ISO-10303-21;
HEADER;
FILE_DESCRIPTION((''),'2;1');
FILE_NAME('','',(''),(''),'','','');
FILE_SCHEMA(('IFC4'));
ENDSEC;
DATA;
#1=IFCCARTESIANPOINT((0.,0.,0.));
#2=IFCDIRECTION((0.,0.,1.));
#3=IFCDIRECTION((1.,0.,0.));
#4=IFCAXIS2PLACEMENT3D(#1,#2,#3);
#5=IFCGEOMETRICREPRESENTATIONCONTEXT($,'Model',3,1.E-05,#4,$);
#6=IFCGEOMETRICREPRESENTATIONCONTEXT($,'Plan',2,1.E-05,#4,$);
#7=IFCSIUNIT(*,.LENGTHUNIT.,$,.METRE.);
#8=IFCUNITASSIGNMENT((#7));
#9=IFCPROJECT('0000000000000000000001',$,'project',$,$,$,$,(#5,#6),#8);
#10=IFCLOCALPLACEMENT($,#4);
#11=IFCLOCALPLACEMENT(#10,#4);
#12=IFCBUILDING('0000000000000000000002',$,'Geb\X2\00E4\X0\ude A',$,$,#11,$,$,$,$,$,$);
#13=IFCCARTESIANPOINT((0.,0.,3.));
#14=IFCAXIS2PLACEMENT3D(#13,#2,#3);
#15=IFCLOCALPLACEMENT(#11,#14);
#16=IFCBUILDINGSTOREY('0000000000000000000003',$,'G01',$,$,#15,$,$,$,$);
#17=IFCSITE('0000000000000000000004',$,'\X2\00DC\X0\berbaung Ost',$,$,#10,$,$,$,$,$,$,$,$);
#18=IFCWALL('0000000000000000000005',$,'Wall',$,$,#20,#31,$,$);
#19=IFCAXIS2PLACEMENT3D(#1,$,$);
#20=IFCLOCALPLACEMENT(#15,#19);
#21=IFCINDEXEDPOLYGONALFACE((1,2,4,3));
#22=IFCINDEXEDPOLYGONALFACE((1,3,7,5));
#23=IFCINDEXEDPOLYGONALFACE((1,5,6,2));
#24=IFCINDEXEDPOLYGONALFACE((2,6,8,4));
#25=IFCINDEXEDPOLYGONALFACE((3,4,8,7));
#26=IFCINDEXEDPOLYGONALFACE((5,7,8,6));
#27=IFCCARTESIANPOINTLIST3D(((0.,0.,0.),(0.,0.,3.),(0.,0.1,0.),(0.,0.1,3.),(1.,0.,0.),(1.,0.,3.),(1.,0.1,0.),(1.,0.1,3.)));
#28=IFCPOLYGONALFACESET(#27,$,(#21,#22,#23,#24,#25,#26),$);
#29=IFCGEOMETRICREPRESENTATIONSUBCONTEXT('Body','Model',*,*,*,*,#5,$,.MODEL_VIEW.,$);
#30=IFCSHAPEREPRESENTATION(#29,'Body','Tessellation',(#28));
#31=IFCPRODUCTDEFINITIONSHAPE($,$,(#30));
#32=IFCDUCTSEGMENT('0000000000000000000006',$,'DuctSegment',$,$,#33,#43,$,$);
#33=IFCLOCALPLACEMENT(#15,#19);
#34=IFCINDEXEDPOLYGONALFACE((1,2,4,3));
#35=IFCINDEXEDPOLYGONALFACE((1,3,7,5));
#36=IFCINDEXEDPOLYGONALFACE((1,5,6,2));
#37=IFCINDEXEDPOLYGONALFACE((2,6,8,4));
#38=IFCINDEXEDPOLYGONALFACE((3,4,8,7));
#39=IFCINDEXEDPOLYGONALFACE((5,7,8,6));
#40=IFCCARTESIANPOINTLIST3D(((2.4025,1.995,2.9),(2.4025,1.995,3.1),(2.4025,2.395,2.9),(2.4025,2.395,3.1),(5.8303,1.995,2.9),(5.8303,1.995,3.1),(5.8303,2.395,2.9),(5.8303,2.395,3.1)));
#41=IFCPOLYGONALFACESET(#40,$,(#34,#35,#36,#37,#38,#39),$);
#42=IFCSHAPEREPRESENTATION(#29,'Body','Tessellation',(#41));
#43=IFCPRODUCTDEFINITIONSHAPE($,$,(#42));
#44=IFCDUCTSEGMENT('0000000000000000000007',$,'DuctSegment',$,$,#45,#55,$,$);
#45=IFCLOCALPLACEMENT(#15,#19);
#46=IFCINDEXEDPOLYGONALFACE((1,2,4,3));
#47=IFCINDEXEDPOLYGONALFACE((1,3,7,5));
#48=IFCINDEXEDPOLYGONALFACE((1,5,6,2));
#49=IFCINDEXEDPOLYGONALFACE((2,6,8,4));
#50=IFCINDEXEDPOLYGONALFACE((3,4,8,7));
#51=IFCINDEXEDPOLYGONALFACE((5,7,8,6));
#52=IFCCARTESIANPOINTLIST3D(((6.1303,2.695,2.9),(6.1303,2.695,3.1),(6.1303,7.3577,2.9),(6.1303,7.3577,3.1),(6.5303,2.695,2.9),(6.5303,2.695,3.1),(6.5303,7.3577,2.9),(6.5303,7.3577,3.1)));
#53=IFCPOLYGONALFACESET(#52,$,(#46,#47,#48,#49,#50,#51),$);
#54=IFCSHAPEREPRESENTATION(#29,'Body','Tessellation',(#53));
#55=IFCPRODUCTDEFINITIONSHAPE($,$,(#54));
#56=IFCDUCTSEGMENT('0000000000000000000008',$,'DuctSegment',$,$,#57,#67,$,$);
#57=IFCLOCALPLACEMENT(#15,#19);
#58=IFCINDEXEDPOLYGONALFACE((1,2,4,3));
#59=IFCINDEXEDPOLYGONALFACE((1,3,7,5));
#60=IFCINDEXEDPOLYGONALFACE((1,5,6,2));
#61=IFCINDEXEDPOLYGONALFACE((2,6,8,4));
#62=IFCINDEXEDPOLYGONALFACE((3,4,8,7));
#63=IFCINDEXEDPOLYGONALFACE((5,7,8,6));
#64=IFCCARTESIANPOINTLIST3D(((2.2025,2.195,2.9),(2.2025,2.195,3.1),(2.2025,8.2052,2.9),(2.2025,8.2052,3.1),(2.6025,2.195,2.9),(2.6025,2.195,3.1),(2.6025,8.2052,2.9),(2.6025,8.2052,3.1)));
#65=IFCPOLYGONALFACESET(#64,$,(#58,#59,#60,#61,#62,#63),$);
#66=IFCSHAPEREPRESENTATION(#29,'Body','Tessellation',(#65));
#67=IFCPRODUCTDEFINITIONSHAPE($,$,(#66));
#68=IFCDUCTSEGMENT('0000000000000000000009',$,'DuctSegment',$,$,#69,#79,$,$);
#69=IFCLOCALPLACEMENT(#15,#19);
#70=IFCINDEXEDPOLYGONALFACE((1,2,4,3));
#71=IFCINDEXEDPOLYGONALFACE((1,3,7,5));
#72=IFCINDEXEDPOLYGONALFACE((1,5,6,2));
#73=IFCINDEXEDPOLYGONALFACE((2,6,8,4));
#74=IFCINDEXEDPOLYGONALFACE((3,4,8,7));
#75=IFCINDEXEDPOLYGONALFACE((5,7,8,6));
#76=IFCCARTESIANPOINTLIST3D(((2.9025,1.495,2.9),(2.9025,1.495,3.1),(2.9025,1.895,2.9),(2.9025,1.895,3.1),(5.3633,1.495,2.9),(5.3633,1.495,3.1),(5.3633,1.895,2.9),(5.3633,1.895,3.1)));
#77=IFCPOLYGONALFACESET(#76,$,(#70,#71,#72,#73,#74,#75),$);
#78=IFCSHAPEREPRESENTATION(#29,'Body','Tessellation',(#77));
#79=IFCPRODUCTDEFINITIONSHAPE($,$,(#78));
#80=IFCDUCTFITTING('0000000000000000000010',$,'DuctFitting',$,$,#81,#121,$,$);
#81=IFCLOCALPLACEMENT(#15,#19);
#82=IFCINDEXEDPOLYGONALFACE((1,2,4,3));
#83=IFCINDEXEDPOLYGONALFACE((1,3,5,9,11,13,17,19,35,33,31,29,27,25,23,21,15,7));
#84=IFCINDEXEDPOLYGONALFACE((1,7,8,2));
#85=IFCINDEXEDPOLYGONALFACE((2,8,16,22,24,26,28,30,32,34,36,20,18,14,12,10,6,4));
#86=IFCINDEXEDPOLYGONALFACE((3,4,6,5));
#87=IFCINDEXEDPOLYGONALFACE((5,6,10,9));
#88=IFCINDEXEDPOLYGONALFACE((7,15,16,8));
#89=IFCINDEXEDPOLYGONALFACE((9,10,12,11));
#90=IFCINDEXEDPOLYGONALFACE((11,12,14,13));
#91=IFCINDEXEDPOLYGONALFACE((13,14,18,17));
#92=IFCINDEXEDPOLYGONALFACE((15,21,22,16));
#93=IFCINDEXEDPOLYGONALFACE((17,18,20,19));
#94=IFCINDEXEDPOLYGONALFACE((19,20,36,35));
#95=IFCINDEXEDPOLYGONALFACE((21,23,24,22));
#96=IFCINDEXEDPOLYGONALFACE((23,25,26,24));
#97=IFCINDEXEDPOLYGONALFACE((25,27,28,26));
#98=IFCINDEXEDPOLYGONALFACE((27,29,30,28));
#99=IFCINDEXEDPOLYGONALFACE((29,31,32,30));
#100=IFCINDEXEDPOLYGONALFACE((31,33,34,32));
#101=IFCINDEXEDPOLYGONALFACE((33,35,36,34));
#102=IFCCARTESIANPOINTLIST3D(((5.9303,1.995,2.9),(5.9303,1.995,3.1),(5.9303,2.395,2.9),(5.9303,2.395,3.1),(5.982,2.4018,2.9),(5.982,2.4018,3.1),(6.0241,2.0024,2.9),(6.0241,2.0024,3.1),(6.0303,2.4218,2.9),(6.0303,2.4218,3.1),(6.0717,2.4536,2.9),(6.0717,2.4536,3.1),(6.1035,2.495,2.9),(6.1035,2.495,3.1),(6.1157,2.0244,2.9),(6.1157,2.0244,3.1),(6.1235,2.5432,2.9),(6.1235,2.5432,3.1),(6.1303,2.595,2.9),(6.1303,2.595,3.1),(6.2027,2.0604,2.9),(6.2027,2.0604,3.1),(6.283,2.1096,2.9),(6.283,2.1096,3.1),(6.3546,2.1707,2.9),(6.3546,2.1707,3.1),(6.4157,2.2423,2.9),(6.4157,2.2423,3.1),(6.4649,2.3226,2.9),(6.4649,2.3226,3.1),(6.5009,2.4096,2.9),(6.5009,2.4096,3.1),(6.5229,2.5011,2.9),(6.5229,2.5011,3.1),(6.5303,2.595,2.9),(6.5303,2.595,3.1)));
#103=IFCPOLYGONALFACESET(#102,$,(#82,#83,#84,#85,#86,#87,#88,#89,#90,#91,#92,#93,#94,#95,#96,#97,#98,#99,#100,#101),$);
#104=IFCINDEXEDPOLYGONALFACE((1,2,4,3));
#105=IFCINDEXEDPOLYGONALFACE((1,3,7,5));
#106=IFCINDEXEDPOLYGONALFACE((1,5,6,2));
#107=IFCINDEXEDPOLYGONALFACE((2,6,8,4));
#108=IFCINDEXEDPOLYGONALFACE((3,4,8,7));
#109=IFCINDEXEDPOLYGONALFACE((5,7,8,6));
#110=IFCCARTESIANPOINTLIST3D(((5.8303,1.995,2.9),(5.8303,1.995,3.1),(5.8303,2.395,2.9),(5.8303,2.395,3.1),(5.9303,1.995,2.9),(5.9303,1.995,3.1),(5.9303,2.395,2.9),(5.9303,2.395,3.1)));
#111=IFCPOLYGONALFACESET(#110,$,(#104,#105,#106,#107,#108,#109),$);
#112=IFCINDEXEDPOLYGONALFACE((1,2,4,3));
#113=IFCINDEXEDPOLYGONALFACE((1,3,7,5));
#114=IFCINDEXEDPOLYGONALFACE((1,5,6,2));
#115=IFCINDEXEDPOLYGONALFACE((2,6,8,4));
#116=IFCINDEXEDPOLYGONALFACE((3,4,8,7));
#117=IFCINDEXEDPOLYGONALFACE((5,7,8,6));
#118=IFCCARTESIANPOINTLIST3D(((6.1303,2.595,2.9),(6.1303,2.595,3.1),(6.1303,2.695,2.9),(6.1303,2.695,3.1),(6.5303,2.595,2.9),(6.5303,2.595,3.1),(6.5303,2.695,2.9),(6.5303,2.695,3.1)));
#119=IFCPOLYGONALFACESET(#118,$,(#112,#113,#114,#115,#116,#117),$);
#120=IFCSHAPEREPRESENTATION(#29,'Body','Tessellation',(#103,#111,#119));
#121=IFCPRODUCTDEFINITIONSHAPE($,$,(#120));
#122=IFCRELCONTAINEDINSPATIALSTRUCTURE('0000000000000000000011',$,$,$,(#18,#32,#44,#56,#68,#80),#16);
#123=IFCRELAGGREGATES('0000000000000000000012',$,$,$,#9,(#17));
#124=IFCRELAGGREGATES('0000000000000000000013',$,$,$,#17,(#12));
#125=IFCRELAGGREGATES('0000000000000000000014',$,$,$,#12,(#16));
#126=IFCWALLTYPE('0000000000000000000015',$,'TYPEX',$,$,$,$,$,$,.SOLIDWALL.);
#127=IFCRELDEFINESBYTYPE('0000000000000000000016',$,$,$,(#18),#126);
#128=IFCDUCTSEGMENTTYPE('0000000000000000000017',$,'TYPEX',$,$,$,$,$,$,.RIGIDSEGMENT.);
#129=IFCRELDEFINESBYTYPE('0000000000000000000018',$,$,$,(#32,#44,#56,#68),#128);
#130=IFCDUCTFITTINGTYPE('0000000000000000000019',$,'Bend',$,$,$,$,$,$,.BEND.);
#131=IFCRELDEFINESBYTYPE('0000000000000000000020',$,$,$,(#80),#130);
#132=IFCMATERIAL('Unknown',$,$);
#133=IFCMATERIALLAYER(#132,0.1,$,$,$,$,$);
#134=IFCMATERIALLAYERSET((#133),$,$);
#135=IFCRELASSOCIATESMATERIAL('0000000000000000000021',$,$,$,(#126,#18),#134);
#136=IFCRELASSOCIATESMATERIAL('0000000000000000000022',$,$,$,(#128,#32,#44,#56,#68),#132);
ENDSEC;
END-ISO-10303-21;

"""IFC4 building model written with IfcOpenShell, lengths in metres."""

from ifc_helpers import new_model, si_unit, frame, origin_with_axes, place, context, subcontext, project, spatial, line, arc, indexed_curve, rectangle, outline, extrude, source, transform, mapped, material, layer, layer_set, layer_usage, material_profile, profile_set, profile_usage, type_object, type_shapes, element, save


model = new_model("IFC4")

# Units and contexts
model_context = context("Model", 3, precision=1e-05, world=origin_with_axes())
plan_context = context("Plan", 2, precision=1e-05, world=origin_with_axes())
body_context = subcontext(model_context, "Body", "Model", "MODEL_VIEW")
ifc_project = project(units=[si_unit("LENGTHUNIT", "METRE")], contexts=[model_context, plan_context])

# Site, building, storey
site_placement = place(None, origin_with_axes())
site = spatial("IfcSite", under=ifc_project, at=site_placement, Name="Überbaung Ost")
building_placement = place(site_placement, origin_with_axes())
building = spatial("IfcBuilding", under=site, at=building_placement, Name="Gebäude A")
storey_placement = place(building_placement, frame((0.0, 0.0, 3.0), z_axis=(0.0, 0.0, 1.0), x_axis=(1.0, 0.0, 0.0)))
storey = spatial("IfcBuildingStorey", under=building, at=storey_placement, Name="G01")

# Wall
ifc_material = material(Name="Unknown")
ifc_layer = layer(ifc_material, 0.1)
ifc_layer_set = layer_set([ifc_layer])
ifc_layer_usage = layer_usage(ifc_layer_set, "AXIS2", "POSITIVE", 0.0)
wall_type = type_object("IfcWallType", Name="TYPEX", PredefinedType="SOLIDWALL", material=ifc_layer_set)
wall_placement = place(storey_placement, origin_with_axes())
element("IfcWall", 1, at=wall_placement, inside=storey, type_object=wall_type, material=ifc_layer_usage, Name="Wall", context=body_context, shape_type="SweptSolid", body=[
    extrude(outline(indexed_curve([(0.0, 0.0), (0.0, 0.1), (1.0, 0.1), (1.0, 0.0), (0.0, 0.0)], self_intersect=False)), origin_with_axes(), (0.0, 0.0, 1.0), 3.0),
])

# Duct segments
ifc_material_profile = material_profile(ifc_material, rectangle(XDim=0.4, YDim=0.2))
ifc_profile_set = profile_set([ifc_material_profile])
ifc_profile_usage_1 = profile_usage(ifc_profile_set, cardinal=5)
duct_segment_type = type_object("IfcDuctSegmentType", Name="TYPEX", PredefinedType="RIGIDSEGMENT", material=ifc_profile_set)
duct_segment_1_placement = place(storey_placement, frame((2.4025, 2.195, 3.0), z_axis=(1.0, 0.0, 0.0), x_axis=(0.0, 1.0, 0.0)))
element("IfcDuctSegment", 2, at=duct_segment_1_placement, inside=storey, type_object=duct_segment_type, material=ifc_profile_usage_1, Name="DuctSegment", context=body_context, shape_type="SweptSolid", body=[
    extrude(rectangle(XDim=0.4, YDim=0.2), origin_with_axes(), (0.0, 0.0, 1.0), 3.4277),
])
ifc_profile_usage_2 = profile_usage(ifc_profile_set, cardinal=5)
duct_segment_2_placement = place(storey_placement, frame((6.3303, 2.695, 3.0), z_axis=(0.0, 1.0, 0.0), x_axis=(-1.0, 0.0, 0.0)))
element("IfcDuctSegment", 3, at=duct_segment_2_placement, inside=storey, type_object=duct_segment_type, material=ifc_profile_usage_2, Name="DuctSegment", context=body_context, shape_type="SweptSolid", body=[
    extrude(rectangle(XDim=0.4, YDim=0.2), origin_with_axes(), (0.0, 0.0, 1.0), 4.6627),
])
ifc_profile_usage_3 = profile_usage(ifc_profile_set, cardinal=5)
duct_segment_3_placement = place(storey_placement, frame((2.4025, 2.195, 3.0), z_axis=(0.0, 1.0, 0.0), x_axis=(-1.0, 0.0, 0.0)))
element("IfcDuctSegment", 4, at=duct_segment_3_placement, inside=storey, type_object=duct_segment_type, material=ifc_profile_usage_3, Name="DuctSegment", context=body_context, shape_type="SweptSolid", body=[
    extrude(rectangle(XDim=0.4, YDim=0.2), origin_with_axes(), (0.0, 0.0, 1.0), 6.0102),
])
ifc_profile_usage_4 = profile_usage(ifc_profile_set, cardinal=5)
duct_segment_4_placement = place(storey_placement, frame((2.9025, 1.695, 3.0), z_axis=(1.0, 0.0, 0.0), x_axis=(0.0, 1.0, 0.0)))
element("IfcDuctSegment", 5, at=duct_segment_4_placement, inside=storey, type_object=duct_segment_type, material=ifc_profile_usage_4, Name="DuctSegment", context=body_context, shape_type="SweptSolid", body=[
    extrude(rectangle(XDim=0.4, YDim=0.2), origin_with_axes(), (0.0, 0.0, 1.0), 2.4608),
])

# Duct fitting
duct_fitting_type = type_object("IfcDuctFittingType", Name="Bend", PredefinedType="BEND")
shared_shape = source(origin_with_axes(), body_context, "Body", "SweptSolid", [
    extrude(outline(indexed_curve([(0.2, 0.0), (0.2586, 0.1414), (0.4, 0.2), (0.4, 0.6), (-0.0243, 0.4243), (-0.2, 0.0)], segments=[arc(1, 2, 3), line(3, 4), arc(4, 5, 6), line(6, 1)])), frame((0.0, -0.1, 0.1), z_axis=(0.0, -1.0, 0.0), x_axis=(1.0, 0.0, 0.0)), (0.0, 0.0, -1.0), 0.2),
    extrude(rectangle(XDim=0.4, YDim=0.2), origin_with_axes(), (0.0, 0.0, 1.0), 0.1),
    extrude(rectangle(XDim=0.4, YDim=0.2), frame((0.4, 0.0, 0.5), z_axis=(1.0, 0.0, 0.0), x_axis=(0.0, 0.0, 1.0)), (0.0, 0.0, 1.0), 0.1),
])
type_shapes(duct_fitting_type, [shared_shape])
duct_fitting_placement = place(storey_placement, frame((5.8303, 2.195, 3.0), z_axis=(1.0, 0.0, 0.0), x_axis=(0.0, 1.0, 0.0)))
element("IfcDuctFitting", 6, at=duct_fitting_placement, inside=storey, type_object=duct_fitting_type, Name="DuctFitting", context=body_context, shape_type="MappedRepresentation", body=[
    mapped(shared_shape, transform((0.0, 0.0, 0.0), x_axis=(1.0, 0.0, 0.0), y_axis=(0.0, 1.0, 0.0), z_axis=(0.0, 0.0, 1.0), scale=1.0)),
])

save(model, "model.ifc")
